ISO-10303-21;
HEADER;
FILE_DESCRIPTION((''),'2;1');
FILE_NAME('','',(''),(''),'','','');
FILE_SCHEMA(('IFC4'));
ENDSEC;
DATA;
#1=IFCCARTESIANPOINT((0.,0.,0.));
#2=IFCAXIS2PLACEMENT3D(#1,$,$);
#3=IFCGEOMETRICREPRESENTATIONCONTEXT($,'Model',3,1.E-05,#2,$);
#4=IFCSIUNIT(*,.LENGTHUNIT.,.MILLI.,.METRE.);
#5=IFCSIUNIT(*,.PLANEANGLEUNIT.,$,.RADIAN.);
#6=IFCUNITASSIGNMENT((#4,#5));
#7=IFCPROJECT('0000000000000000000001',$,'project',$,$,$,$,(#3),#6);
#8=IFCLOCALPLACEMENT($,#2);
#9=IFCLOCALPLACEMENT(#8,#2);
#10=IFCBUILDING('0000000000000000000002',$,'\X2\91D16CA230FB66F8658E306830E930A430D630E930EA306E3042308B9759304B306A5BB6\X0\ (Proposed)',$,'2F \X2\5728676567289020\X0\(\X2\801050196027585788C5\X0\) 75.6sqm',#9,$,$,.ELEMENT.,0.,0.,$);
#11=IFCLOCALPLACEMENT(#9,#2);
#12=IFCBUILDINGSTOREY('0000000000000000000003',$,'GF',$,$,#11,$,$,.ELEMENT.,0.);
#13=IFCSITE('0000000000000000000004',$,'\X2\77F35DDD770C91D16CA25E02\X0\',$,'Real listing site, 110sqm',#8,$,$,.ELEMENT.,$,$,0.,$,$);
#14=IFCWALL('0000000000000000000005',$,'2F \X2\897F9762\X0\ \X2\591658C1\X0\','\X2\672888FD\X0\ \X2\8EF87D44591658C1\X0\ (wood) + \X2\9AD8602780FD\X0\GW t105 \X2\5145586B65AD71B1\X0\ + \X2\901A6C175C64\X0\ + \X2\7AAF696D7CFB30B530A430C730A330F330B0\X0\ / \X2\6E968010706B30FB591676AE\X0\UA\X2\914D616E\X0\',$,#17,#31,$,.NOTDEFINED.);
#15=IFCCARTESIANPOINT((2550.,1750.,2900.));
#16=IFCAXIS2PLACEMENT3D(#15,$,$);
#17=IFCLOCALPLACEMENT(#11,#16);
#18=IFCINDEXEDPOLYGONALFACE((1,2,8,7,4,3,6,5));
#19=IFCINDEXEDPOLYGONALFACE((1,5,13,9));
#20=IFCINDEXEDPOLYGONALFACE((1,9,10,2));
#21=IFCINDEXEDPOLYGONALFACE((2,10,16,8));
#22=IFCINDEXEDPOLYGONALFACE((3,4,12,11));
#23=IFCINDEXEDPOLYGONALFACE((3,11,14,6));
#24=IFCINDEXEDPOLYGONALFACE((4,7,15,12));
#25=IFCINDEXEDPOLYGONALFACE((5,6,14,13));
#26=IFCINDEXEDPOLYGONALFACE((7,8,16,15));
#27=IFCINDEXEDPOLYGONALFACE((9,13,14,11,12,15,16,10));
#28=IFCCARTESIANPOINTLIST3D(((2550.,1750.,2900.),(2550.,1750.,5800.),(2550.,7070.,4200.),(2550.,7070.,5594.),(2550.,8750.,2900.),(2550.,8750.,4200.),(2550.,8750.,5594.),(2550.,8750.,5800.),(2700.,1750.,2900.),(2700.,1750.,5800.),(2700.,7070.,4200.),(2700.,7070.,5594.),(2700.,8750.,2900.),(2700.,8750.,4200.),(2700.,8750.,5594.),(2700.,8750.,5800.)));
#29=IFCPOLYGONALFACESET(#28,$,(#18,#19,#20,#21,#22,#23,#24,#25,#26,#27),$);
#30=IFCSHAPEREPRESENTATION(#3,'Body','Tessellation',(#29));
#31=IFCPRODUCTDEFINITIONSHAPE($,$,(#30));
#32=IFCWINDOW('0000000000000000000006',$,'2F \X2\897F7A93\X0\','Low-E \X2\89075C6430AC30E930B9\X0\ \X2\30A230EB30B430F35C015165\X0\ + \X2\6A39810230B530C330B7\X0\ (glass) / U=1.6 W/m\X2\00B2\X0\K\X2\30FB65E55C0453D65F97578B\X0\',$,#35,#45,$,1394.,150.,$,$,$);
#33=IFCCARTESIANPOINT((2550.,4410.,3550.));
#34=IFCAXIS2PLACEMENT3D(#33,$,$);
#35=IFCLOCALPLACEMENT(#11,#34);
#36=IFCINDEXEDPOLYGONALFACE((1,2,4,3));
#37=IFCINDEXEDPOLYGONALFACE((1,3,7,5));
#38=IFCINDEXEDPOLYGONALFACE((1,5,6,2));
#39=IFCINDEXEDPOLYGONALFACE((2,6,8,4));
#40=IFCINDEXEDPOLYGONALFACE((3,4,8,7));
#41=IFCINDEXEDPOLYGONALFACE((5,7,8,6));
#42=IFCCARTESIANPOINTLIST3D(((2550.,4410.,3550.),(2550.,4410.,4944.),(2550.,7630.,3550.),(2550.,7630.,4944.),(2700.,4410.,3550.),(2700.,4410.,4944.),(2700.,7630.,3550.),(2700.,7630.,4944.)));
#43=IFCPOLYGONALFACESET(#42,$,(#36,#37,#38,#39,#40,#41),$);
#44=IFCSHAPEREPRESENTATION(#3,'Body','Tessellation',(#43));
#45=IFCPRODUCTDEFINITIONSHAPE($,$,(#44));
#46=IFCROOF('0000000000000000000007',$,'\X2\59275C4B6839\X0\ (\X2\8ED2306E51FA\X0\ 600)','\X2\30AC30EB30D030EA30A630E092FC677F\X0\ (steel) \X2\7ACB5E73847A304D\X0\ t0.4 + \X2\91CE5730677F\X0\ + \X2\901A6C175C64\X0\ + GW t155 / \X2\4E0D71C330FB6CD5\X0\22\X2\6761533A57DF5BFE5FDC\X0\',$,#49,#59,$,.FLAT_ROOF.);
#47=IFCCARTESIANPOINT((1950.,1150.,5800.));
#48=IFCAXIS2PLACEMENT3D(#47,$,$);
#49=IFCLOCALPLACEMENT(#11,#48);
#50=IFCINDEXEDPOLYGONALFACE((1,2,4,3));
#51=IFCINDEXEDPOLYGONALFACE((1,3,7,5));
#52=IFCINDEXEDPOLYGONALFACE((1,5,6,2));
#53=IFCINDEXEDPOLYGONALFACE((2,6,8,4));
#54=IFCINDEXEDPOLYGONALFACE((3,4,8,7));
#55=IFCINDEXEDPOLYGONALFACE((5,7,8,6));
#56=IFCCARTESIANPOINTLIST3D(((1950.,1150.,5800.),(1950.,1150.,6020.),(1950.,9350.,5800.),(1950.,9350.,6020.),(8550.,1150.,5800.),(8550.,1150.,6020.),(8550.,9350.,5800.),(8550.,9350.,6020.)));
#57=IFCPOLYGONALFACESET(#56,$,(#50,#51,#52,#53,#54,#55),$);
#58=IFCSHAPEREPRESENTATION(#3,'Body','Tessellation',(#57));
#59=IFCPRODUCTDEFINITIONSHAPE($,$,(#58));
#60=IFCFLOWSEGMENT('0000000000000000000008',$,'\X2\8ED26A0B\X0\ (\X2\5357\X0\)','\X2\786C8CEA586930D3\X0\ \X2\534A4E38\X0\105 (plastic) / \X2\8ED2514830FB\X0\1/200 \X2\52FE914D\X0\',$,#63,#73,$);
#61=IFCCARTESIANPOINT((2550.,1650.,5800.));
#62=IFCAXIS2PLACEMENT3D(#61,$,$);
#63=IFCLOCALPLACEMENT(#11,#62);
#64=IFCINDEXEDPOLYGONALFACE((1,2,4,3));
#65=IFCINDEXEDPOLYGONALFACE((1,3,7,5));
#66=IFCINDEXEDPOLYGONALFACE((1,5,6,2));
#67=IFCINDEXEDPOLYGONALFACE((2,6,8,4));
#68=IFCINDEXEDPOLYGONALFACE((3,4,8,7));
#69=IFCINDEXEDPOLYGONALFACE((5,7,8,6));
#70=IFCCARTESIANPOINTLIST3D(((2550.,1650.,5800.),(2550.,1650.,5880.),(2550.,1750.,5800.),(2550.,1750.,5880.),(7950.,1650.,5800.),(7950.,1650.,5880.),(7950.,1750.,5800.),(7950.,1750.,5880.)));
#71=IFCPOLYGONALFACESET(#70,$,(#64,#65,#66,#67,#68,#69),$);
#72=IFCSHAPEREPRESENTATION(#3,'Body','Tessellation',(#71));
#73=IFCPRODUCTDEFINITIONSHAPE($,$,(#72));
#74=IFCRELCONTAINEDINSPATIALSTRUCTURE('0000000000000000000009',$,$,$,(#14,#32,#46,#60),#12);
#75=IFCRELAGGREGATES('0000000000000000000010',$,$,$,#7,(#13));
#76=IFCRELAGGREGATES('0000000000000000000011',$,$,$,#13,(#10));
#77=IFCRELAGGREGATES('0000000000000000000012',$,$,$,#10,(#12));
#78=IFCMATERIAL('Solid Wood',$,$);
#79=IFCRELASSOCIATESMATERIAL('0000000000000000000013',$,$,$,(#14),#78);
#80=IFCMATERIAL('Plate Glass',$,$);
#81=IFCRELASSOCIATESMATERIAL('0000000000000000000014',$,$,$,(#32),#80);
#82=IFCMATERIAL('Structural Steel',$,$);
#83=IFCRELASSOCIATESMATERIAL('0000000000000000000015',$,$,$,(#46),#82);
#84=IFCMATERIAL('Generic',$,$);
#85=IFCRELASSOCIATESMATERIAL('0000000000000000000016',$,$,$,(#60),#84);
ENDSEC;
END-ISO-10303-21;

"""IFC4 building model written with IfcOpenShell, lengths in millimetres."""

from ifc_helpers import new_model, si_unit, frame, frame_2d, origin, place, context, project, spatial, rectangle, extrude, material, element, fill, save


model = new_model("IFC4")

# Units and contexts
model_context = context("Model", 3, precision=1e-05, world=origin())
ifc_project = project(units=[si_unit("LENGTHUNIT", "METRE", prefix="MILLI"), si_unit("PLANEANGLEUNIT", "RADIAN")], contexts=[model_context])

# Site, building, storey
site_placement = place(None, origin())
site = spatial("IfcSite", under=ifc_project, at=site_placement, Name="石川県金沢市", ObjectType="Real listing site, 110sqm", CompositionType="ELEMENT", RefElevation=0.0)
building_placement = place(site_placement, origin())
building = spatial("IfcBuilding", under=site, at=building_placement, Name="金沢・書斎とライブラリのある静かな家 (Proposed)", ObjectType="2F 在来木造(耐候性塗装) 75.6sqm", CompositionType="ELEMENT", ElevationOfRefHeight=0.0, ElevationOfTerrain=0.0)
storey_placement = place(building_placement, origin())
storey = spatial("IfcBuildingStorey", under=building, at=storey_placement, Name="GF", CompositionType="ELEMENT", Elevation=0.0)

# Shared definitions
ifc_material_1 = material(Name="Solid Wood")

# Shared definitions
ifc_material_2 = material(Name="Plate Glass")

# Wall, opening, window
wall_1_placement = place(storey_placement, frame((2550.0, 1750.0, 2900.0)))
wall_1 = element("IfcWall", 1, at=wall_1_placement, inside=storey, material=ifc_material_1, Name="2F 西面 外壁", Description="木製 軸組外壁 (wood) + 高性能GW t105 充填断熱 + 通気層 + 窯業系サイディング / 準耐火・外皮UA配慮", PredefinedType="NOTDEFINED", context=model_context, shape_type="SweptSolid", body=[
    extrude(rectangle(XDim=150.0, YDim=7000.0, at=frame_2d((75.0, 3500.0))), frame((2550.0, 1750.0, 2900.0)), (0.0, 0.0, 1.0), 2900.0),
])
opening_1_placement = place(storey_placement, frame((2550.0, 4410.0, 3550.0)))
opening_1 = element("IfcOpeningElement", 2, at=opening_1_placement, cuts=wall_1, PredefinedType="NOTDEFINED", context=model_context, shape_type="SweptSolid", body=[
    extrude(rectangle(XDim=150.0, YDim=3220.0, at=frame_2d((75.0, 1610.0))), frame((2550.0, 4410.0, 3550.0)), (0.0, 0.0, 1.0), 1394.0),
])
window_1_placement = place(storey_placement, frame((2550.0, 4410.0, 3550.0)))
window_1 = element("IfcWindow", 3, at=window_1_placement, inside=storey, material=ifc_material_2, Name="2F 西窓", Description="Low-E 複層ガラス アルゴン封入 + 樹脂サッシ (glass) / U=1.6 W/m²K・日射取得型", OverallHeight=1394.0, OverallWidth=150.0, context=model_context, shape_type="SweptSolid", body=[
    extrude(rectangle(XDim=150.0, YDim=3220.0, at=frame_2d((75.0, 1610.0))), frame((2550.0, 4410.0, 3550.0)), (0.0, 0.0, 1.0), 1394.0),
])
fill(opening_1, window_1)

# Roof
ifc_material_3 = material(Name="Structural Steel")
roof_placement = place(storey_placement, frame((1950.0, 1150.0, 5800.0)))
element("IfcRoof", 4, at=roof_placement, inside=storey, material=ifc_material_3, Name="大屋根 (軒の出 600)", Description="ガルバリウム鋼板 (steel) 立平葺き t0.4 + 野地板 + 通気層 + GW t155 / 不燃・法22条区域対応", PredefinedType="FLAT_ROOF", context=model_context, shape_type="SweptSolid", body=[
    extrude(rectangle(XDim=6600.0, YDim=8200.0, at=frame_2d((3300.0, 4100.0))), frame((1950.0, 1150.0, 5800.0)), (0.0, 0.0, 1.0), 220.0),
])

# Flow segment
ifc_material_4 = material(Name="Generic")
flow_segment_placement = place(storey_placement, frame((2550.0, 1650.0, 5800.0)))
element("IfcFlowSegment", 5, at=flow_segment_placement, inside=storey, material=ifc_material_4, Name="軒樋 (南)", Description="硬質塩ビ 半丸105 (plastic) / 軒先・1/200 勾配", context=model_context, shape_type="SweptSolid", body=[
    extrude(rectangle(XDim=5400.0, YDim=100.0, at=frame_2d((2700.0, 50.0))), frame((2550.0, 1650.0, 5800.0)), (0.0, 0.0, 1.0), 80.0),
])

save(model, "model.ifc")
